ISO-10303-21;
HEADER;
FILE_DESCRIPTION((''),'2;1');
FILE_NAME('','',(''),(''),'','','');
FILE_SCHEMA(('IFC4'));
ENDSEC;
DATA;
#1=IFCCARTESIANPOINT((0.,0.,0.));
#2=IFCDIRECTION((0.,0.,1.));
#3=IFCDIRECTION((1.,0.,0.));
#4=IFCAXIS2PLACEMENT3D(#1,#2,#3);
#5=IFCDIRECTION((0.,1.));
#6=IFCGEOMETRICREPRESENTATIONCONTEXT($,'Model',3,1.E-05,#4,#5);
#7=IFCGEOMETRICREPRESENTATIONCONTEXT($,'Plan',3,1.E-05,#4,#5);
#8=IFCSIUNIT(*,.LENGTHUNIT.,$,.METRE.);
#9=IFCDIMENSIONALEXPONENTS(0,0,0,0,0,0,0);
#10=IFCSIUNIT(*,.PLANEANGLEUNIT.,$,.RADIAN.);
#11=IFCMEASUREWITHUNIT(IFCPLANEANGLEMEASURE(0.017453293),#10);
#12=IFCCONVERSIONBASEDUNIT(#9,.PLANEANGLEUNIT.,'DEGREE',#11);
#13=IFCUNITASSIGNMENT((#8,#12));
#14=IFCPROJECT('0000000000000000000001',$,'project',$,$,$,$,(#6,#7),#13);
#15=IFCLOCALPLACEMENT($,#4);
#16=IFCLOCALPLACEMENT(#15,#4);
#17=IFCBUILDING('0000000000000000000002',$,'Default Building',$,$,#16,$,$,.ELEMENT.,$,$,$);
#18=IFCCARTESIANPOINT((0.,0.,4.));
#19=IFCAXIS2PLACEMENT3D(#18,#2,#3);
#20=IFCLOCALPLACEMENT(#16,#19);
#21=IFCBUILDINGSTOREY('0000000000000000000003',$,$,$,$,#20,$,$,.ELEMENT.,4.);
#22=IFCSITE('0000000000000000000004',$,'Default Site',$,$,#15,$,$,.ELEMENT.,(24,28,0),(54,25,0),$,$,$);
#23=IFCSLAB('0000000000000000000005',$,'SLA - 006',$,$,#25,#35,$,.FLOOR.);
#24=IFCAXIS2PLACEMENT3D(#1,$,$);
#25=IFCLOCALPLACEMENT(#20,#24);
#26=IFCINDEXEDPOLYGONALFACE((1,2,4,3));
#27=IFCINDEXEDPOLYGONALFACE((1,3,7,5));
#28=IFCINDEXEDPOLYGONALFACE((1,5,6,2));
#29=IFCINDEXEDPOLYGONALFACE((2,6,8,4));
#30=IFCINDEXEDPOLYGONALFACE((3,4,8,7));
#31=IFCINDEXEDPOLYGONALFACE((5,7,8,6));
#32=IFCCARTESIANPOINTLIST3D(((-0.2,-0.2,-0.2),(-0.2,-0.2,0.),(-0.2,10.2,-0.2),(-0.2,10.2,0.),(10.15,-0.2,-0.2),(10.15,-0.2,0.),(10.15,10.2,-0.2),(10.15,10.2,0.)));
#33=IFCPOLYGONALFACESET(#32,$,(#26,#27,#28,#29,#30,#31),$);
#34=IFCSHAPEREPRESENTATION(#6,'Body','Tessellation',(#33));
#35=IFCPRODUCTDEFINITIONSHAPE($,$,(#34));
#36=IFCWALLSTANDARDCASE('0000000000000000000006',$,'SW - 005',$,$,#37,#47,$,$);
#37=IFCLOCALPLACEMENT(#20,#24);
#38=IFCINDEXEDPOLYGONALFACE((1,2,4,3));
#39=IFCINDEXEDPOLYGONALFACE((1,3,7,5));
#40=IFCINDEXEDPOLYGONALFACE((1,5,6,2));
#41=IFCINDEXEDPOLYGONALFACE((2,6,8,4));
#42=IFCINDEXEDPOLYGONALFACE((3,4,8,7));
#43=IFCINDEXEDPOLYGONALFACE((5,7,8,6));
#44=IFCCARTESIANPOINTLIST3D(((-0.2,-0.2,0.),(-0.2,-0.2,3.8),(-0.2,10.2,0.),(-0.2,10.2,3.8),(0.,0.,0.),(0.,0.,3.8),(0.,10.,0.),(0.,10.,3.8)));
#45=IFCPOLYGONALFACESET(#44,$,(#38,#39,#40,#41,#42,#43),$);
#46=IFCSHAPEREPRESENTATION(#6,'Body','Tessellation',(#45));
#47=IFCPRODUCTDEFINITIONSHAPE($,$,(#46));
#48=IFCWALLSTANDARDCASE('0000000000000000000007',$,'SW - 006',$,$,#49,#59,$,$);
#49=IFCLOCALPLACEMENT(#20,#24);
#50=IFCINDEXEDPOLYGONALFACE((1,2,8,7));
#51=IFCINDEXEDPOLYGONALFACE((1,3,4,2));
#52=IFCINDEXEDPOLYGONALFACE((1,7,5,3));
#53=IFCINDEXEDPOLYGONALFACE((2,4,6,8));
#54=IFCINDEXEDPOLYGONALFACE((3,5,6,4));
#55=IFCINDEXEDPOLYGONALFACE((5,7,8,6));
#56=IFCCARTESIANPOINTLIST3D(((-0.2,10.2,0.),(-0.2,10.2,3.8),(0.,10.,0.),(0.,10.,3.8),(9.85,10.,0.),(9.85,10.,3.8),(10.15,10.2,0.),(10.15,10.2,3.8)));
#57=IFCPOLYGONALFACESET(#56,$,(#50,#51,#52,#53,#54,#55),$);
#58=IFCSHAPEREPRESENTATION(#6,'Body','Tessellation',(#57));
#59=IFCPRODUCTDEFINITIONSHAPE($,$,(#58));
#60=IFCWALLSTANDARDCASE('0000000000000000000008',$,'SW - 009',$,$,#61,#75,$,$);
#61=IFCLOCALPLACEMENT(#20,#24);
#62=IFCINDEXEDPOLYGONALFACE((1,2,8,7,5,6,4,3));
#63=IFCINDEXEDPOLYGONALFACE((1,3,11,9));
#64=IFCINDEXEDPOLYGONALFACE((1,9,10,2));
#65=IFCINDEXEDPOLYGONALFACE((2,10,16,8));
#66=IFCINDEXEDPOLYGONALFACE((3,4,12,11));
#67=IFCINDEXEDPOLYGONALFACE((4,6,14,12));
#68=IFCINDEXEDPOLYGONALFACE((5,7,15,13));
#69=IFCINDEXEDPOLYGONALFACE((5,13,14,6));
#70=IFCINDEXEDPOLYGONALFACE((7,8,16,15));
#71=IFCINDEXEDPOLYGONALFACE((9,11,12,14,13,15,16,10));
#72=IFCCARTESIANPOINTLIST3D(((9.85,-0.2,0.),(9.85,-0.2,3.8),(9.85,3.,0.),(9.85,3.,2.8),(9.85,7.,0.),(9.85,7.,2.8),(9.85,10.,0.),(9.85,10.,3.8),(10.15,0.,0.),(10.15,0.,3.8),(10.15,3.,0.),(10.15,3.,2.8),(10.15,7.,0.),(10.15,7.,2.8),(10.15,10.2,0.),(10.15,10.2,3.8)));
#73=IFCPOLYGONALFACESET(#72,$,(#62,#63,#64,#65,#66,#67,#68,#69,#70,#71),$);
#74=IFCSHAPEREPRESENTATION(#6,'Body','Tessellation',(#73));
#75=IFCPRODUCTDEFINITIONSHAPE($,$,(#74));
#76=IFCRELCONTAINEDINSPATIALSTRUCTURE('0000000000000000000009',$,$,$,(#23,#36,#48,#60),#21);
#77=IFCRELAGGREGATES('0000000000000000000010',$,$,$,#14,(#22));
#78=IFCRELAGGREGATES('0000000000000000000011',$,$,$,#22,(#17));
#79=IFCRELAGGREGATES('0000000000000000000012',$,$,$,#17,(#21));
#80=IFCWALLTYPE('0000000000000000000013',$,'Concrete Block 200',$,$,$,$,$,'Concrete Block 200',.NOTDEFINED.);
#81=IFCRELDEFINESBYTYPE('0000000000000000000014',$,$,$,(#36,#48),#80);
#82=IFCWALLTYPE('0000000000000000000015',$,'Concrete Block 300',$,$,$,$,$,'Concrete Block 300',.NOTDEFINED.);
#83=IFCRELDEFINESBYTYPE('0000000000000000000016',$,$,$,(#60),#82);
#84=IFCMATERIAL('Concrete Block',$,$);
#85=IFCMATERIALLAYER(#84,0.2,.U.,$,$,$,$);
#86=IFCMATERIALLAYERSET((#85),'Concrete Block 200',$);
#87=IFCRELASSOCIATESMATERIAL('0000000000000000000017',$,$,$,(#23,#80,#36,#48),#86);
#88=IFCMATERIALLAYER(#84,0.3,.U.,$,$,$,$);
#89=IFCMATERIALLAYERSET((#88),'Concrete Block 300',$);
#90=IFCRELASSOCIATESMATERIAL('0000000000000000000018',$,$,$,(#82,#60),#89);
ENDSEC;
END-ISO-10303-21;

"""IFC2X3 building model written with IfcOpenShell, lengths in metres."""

from ifc_helpers import new_model, entity, si_unit, converted_unit, direction, frame, frame_2d, origin_with_axes, place, context, project, spatial, polyline, rectangle, outline, extrude, material, layer, layer_set, layer_usage, type_object, element, save


model = new_model("IFC2X3")

# Units and contexts
model_context = context("Model", 3, precision=1e-05, world=origin_with_axes(), true_north=direction((0.0, 1.0)))
plan_context = context("Plan", 3, precision=1e-05, world=origin_with_axes(), true_north=direction((0.0, 1.0)))
ifc_project = project(units=[si_unit("LENGTHUNIT", "METRE"), converted_unit("PLANEANGLEUNIT", "DEGREE", entity("IfcPlaneAngleMeasure", 0.017453293), si_unit("PLANEANGLEUNIT", "RADIAN"), dimensions=[0, 0, 0, 0, 0, 0, 0])], contexts=[model_context, plan_context])

# Site, building, storey
site_placement = place(None, origin_with_axes())
site = spatial("IfcSite", under=ifc_project, at=site_placement, Name="Default Site", CompositionType="ELEMENT", RefLatitude=(24, 28, 0), RefLongitude=(54, 25, 0))
building_placement = place(site_placement, origin_with_axes())
building = spatial("IfcBuilding", under=site, at=building_placement, Name="Default Building", CompositionType="ELEMENT")
storey_placement = place(building_placement, frame((0.0, 0.0, 4.0), z_axis=(0.0, 0.0, 1.0), x_axis=(1.0, 0.0, 0.0)))
storey = spatial("IfcBuildingStorey", under=building, at=storey_placement, CompositionType="ELEMENT", Elevation=4.0)

# Slab
ifc_material = material(Name="Concrete Block")
ifc_layer_1 = layer(ifc_material, 0.2, ventilated="UNKNOWN")
ifc_layer_set_1 = layer_set([ifc_layer_1], Name="Concrete Block 200")
ifc_layer_usage_1 = layer_usage(ifc_layer_set_1, "AXIS3", "NEGATIVE", 0.2)
slab_placement = place(storey_placement, frame((-0.2, 10.2, -0.2), z_axis=(0.0, 0.0, 1.0), x_axis=(0.0, -1.0, 0.0)))
element("IfcSlab", 1, at=slab_placement, inside=storey, material=ifc_layer_usage_1, Name="SLA - 006", PredefinedType="FLOOR", context=model_context, shape_type="SweptSolid", body=[
    extrude(outline(polyline([(0.0, 0.0), (10.4, 0.0), (10.4, 10.35), (0.0, 10.35), (0.0, 0.0)])), origin_with_axes(), (0.0, 0.0, 1.0), 0.2),
])

# Walls
ifc_layer_usage_2 = layer_usage(ifc_layer_set_1, "AXIS2", "POSITIVE", 0.0)
wall_type_1 = type_object("IfcWallType", Name="Concrete Block 200", ElementType="Concrete Block 200", PredefinedType="NOTDEFINED", material=ifc_layer_set_1)
wall_1_placement = place(storey_placement, frame((0.0, 0.0, 0.0), z_axis=(0.0, 0.0, 1.0), x_axis=(0.0, 1.0, 0.0)))
element("IfcWallStandardCase", 2, at=wall_1_placement, inside=storey, type_object=wall_type_1, material=ifc_layer_usage_2, Name="SW - 005", context=model_context, shape_type="SweptSolid", body=[
    extrude(outline(polyline([(0.0, 0.0), (10.0, 0.0), (10.2, 0.2), (-0.2, 0.2), (0.0, 0.0)])), origin_with_axes(), (0.0, 0.0, 1.0), 3.8),
])
ifc_layer_usage_3 = layer_usage(ifc_layer_set_1, "AXIS2", "POSITIVE", 0.0)
wall_2_placement = place(storey_placement, frame((0.0, 10.0, 0.0), z_axis=(0.0, 0.0, 1.0), x_axis=(1.0, 0.0, 0.0)))
element("IfcWallStandardCase", 3, at=wall_2_placement, inside=storey, type_object=wall_type_1, material=ifc_layer_usage_3, Name="SW - 006", context=model_context, shape_type="SweptSolid", body=[
    extrude(outline(polyline([(0.0, 0.0), (9.85, 0.0), (10.15, 0.2), (-0.2, 0.2), (0.0, 0.0)])), origin_with_axes(), (0.0, 0.0, 1.0), 3.8),
])

# Wall, opening
ifc_layer_2 = layer(ifc_material, 0.3, ventilated="UNKNOWN")
ifc_layer_set_2 = layer_set([ifc_layer_2], Name="Concrete Block 300")
ifc_layer_usage_4 = layer_usage(ifc_layer_set_2, "AXIS2", "POSITIVE", 0.0)
wall_type_2 = type_object("IfcWallType", Name="Concrete Block 300", ElementType="Concrete Block 300", PredefinedType="NOTDEFINED", material=ifc_layer_set_2)
wall_3_placement = place(storey_placement, frame((10.15, 0.0, 0.0), z_axis=(0.0, 0.0, 1.0), x_axis=(0.0, 1.0, 0.0)))
wall_3 = element("IfcWallStandardCase", 4, at=wall_3_placement, inside=storey, type_object=wall_type_2, material=ifc_layer_usage_4, Name="SW - 009", context=model_context, shape_type="SweptSolid", body=[
    extrude(outline(polyline([(0.0, 0.0), (10.2, 0.0), (10.0, 0.3), (-0.2, 0.3), (0.0, 0.0)])), origin_with_axes(), (0.0, 0.0, 1.0), 3.8),
])
opening_placement = place(wall_3_placement, frame((5.0, 0.0, 0.0), z_axis=(0.0, 0.0, 1.0), x_axis=(1.0, 0.0, 0.0)))
element("IfcOpeningElement", 5, at=opening_placement, cuts=wall_3, ObjectType="Opening", context=model_context, shape_type="SweptSolid", body=[
    extrude(rectangle(XDim=4.0, YDim=2.8, at=frame_2d((0.0, 1.4), x_axis=(-1.0, 0.0))), frame((0.0, 0.0, 0.0), z_axis=(0.0, 1.0, 0.0), x_axis=(-1.0, 0.0, 0.0)), (0.0, 0.0, 1.0), 0.3),
])

save(model, "model.ifc")
